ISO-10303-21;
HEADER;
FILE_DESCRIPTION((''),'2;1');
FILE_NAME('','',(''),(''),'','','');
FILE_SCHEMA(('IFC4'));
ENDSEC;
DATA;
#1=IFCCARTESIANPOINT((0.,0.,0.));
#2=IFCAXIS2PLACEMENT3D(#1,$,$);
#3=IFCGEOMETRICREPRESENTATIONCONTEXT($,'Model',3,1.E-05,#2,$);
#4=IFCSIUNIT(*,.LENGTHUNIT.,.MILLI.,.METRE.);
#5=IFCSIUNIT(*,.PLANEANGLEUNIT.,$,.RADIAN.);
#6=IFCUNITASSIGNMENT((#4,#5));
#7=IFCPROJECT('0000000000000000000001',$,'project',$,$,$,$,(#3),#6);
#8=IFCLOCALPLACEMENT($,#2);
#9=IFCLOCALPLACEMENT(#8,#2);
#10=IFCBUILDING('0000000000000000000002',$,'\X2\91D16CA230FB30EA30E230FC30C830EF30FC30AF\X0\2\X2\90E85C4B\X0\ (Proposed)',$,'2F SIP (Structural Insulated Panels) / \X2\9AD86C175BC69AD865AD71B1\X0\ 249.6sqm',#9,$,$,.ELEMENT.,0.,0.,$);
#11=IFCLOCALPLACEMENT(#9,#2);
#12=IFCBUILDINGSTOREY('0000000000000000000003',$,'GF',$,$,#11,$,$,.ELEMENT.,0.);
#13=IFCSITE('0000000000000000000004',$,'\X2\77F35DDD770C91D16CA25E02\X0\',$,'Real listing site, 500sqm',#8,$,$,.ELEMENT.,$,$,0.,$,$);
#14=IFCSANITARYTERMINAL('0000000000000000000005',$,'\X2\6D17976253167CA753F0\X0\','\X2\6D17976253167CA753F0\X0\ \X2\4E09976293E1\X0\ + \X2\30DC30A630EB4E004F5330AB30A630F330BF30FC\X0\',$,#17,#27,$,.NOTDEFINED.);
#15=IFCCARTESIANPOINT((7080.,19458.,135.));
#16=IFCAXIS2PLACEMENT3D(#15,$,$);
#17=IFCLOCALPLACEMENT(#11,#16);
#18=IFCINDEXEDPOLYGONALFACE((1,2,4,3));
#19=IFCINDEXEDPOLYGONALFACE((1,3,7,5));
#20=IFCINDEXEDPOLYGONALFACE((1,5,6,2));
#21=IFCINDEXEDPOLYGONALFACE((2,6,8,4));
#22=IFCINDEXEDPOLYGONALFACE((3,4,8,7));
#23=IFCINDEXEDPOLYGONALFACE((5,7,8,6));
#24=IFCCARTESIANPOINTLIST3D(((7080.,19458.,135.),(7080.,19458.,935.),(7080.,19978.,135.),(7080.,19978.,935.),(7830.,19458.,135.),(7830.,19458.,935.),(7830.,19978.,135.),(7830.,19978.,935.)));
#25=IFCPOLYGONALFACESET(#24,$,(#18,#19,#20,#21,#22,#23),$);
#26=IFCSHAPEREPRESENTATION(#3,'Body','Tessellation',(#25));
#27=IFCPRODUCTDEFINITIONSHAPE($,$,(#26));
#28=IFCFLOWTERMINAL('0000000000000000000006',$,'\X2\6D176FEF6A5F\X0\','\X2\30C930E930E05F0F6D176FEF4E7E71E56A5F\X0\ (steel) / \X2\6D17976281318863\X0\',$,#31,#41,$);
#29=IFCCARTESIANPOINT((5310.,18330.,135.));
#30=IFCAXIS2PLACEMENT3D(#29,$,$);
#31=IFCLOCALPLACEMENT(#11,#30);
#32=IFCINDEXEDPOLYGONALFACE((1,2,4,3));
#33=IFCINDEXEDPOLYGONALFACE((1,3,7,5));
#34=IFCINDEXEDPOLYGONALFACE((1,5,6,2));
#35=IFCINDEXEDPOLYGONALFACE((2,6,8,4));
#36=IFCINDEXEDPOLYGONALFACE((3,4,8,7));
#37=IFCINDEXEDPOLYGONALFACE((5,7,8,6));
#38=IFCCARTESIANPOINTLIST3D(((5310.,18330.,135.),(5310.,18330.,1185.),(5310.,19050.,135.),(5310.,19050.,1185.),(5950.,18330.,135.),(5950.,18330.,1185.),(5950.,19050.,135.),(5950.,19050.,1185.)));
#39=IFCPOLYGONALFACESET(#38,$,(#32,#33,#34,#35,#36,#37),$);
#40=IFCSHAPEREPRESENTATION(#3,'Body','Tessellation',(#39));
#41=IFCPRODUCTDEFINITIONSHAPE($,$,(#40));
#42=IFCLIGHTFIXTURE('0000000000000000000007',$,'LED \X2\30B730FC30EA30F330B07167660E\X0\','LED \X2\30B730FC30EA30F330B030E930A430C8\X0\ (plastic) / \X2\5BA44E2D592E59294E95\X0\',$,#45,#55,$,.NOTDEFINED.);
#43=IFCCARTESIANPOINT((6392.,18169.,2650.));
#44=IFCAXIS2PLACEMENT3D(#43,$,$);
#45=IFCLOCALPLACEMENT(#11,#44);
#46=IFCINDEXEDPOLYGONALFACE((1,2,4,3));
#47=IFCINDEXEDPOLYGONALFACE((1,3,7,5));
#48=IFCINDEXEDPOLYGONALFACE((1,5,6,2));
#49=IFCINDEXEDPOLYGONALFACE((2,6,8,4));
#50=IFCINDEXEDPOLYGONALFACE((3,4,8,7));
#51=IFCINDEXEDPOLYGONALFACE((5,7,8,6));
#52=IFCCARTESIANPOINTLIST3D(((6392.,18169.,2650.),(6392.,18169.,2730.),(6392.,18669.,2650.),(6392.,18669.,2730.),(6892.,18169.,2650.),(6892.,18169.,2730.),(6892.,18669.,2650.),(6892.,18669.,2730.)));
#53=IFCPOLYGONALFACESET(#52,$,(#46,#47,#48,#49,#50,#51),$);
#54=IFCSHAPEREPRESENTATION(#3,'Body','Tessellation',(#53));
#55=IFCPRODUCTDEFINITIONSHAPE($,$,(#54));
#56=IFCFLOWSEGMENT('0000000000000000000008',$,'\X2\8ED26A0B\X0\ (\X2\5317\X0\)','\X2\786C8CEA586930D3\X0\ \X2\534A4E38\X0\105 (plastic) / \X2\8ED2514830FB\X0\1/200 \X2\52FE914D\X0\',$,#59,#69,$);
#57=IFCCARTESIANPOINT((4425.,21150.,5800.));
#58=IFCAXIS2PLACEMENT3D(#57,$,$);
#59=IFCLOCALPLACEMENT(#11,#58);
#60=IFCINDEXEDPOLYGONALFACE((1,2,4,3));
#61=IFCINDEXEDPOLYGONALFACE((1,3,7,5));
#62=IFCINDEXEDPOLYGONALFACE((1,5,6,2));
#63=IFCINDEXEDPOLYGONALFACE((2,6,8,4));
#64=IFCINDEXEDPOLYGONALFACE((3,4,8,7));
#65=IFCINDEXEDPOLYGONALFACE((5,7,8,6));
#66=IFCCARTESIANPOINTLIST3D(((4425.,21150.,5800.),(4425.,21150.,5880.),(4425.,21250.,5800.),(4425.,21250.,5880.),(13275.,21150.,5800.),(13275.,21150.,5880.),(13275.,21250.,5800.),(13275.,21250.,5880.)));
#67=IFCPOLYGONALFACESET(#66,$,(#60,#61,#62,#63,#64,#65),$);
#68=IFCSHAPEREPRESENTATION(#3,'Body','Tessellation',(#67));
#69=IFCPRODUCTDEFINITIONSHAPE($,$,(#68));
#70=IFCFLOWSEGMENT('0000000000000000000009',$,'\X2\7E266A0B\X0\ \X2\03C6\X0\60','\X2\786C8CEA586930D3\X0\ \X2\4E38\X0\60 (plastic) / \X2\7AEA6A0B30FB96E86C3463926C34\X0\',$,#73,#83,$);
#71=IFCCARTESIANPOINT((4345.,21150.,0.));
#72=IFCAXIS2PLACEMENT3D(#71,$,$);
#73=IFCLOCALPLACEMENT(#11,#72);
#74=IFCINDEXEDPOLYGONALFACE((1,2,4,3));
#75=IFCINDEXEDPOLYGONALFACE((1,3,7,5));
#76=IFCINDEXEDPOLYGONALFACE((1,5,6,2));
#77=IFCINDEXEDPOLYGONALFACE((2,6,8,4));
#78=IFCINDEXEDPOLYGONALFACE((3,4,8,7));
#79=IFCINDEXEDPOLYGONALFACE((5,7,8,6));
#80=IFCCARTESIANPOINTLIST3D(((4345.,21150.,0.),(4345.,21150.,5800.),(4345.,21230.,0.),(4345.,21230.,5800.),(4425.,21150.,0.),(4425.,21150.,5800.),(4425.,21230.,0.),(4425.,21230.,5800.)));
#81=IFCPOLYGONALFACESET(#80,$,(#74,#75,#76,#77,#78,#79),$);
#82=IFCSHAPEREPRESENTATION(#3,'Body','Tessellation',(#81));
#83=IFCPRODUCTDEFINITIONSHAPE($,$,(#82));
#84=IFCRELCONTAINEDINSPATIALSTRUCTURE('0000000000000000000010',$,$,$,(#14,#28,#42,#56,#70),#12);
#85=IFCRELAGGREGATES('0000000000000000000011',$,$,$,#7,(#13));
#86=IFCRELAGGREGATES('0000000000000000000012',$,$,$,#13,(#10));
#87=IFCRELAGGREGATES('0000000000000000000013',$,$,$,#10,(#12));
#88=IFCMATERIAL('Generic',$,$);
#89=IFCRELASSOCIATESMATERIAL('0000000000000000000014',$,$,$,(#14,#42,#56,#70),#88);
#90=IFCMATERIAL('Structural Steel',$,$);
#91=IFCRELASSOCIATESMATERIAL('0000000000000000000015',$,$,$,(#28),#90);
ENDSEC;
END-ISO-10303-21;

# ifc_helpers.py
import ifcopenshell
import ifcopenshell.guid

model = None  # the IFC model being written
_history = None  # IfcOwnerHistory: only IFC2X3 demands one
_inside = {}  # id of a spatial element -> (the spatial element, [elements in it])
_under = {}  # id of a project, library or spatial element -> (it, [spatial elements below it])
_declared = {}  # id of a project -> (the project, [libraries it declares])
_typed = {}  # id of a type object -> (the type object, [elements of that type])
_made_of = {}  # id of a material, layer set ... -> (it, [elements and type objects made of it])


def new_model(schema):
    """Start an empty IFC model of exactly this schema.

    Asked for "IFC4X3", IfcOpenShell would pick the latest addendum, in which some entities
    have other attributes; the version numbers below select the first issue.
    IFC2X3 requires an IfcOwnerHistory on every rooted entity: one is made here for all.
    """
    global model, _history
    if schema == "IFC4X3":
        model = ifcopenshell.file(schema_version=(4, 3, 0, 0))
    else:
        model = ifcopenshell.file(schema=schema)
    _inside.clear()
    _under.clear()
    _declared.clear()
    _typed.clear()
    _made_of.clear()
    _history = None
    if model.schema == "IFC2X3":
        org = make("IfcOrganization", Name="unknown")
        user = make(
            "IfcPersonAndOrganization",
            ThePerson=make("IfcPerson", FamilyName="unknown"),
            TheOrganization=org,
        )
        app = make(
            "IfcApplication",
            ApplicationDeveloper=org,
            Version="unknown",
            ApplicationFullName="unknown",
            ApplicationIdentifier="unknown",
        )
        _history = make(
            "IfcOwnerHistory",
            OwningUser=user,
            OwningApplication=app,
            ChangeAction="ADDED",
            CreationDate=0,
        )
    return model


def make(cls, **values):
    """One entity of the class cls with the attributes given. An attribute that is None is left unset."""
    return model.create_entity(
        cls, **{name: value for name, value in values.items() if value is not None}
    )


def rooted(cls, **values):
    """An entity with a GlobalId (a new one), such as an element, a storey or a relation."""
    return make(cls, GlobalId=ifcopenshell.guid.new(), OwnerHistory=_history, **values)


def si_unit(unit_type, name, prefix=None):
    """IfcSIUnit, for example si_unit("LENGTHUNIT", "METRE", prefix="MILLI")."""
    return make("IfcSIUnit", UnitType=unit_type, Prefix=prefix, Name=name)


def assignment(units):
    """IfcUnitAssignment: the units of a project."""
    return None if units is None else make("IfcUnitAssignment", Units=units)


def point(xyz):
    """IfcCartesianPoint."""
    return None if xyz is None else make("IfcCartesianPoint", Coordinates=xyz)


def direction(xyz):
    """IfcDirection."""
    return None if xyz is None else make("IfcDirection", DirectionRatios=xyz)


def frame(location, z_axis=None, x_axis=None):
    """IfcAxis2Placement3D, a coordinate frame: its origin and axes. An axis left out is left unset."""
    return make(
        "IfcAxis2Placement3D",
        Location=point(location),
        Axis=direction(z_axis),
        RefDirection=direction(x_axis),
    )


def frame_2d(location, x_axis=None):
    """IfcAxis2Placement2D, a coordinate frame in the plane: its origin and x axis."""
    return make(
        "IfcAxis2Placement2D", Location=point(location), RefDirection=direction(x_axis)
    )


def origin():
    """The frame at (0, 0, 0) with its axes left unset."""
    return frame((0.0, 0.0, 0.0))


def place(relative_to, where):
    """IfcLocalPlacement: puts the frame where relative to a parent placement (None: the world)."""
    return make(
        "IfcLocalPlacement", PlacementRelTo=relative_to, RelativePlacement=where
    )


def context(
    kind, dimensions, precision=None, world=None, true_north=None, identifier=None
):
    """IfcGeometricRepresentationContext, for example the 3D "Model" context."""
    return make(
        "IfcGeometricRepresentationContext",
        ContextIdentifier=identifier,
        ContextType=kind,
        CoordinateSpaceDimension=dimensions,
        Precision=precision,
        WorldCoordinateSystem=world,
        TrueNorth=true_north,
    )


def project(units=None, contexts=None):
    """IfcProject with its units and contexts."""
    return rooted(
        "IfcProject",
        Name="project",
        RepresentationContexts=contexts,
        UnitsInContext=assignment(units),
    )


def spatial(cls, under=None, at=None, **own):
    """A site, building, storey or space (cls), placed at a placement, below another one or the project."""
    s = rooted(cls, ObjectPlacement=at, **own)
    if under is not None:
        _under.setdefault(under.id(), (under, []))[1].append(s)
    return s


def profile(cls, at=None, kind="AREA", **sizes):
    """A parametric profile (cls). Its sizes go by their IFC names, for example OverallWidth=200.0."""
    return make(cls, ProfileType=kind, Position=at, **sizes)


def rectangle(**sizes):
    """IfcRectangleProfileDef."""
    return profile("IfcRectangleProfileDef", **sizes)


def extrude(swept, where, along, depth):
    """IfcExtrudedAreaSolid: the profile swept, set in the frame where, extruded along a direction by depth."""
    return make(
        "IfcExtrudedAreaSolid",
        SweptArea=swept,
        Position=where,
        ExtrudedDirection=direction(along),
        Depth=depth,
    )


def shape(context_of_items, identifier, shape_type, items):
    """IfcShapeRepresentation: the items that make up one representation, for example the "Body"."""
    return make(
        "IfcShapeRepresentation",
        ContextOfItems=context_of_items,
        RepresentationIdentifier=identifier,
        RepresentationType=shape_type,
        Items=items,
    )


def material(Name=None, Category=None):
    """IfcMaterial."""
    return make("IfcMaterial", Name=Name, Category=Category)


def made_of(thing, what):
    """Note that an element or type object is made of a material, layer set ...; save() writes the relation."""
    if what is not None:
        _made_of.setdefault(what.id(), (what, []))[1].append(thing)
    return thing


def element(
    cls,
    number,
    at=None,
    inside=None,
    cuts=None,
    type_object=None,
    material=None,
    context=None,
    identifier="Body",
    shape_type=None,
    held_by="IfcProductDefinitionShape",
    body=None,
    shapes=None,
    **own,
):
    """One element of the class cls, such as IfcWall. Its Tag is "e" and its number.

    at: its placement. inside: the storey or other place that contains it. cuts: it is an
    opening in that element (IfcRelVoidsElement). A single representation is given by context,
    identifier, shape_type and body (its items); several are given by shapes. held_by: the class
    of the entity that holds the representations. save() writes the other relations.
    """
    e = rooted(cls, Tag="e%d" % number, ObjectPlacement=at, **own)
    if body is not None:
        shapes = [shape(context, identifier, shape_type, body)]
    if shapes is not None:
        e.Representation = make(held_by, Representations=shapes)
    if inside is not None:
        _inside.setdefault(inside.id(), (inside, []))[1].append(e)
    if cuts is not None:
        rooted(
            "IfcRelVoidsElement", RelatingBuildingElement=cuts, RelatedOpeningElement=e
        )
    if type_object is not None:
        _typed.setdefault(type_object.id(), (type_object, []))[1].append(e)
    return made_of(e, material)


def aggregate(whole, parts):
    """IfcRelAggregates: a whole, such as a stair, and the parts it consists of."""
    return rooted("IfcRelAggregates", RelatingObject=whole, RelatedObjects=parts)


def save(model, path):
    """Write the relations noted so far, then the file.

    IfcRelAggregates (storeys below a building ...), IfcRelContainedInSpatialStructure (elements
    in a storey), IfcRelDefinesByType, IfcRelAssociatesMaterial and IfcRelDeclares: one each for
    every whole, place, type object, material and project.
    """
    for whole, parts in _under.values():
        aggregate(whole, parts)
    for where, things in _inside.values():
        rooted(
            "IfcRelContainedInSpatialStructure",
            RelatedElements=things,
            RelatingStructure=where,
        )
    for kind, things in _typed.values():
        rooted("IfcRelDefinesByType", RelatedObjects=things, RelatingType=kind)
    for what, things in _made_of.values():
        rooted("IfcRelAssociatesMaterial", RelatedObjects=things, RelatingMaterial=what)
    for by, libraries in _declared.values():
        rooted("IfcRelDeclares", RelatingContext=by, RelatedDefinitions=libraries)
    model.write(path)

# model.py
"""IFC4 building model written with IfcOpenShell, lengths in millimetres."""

from ifc_helpers import new_model, si_unit, frame, frame_2d, origin, place, context, project, spatial, rectangle, extrude, material, element, save


model = new_model("IFC4")

# Units and contexts
model_context = context("Model", 3, precision=1e-05, world=origin())
ifc_project = project(units=[si_unit("LENGTHUNIT", "METRE", prefix="MILLI"), si_unit("PLANEANGLEUNIT", "RADIAN")], contexts=[model_context])

# Site, building, storey
site_placement = place(None, origin())
site = spatial("IfcSite", under=ifc_project, at=site_placement, Name="石川県金沢市", ObjectType="Real listing site, 500sqm", CompositionType="ELEMENT", RefElevation=0.0)
building_placement = place(site_placement, origin())
building = spatial("IfcBuilding", under=site, at=building_placement, Name="金沢・リモートワーク2部屋 (Proposed)", ObjectType="2F SIP (Structural Insulated Panels) / 高気密高断熱 249.6sqm", CompositionType="ELEMENT", ElevationOfRefHeight=0.0, ElevationOfTerrain=0.0)
storey_placement = place(building_placement, origin())
storey = spatial("IfcBuildingStorey", under=building, at=storey_placement, Name="GF", CompositionType="ELEMENT", Elevation=0.0)

# Sanitary terminal
ifc_material_1 = material(Name="Generic")
sanitary_terminal_placement = place(storey_placement, frame((7080.0, 19458.0, 135.0)))
element("IfcSanitaryTerminal", 1, at=sanitary_terminal_placement, inside=storey, material=ifc_material_1, Name="洗面化粧台", Description="洗面化粧台 三面鏡 + ボウル一体カウンター", PredefinedType="NOTDEFINED", context=model_context, shape_type="SweptSolid", body=[
    extrude(rectangle(XDim=750.0, YDim=520.0, at=frame_2d((375.0, 260.0))), frame((7080.0, 19458.0, 135.0)), (0.0, 0.0, 1.0), 800.0),
])

# Flow terminal
ifc_material_2 = material(Name="Structural Steel")
flow_terminal_placement = place(storey_placement, frame((5310.0, 18330.0, 135.0)))
element("IfcFlowTerminal", 2, at=flow_terminal_placement, inside=storey, material=ifc_material_2, Name="洗濯機", Description="ドラム式洗濯乾燥機 (steel) / 洗面脱衣", context=model_context, shape_type="SweptSolid", body=[
    extrude(rectangle(XDim=640.0, YDim=720.0, at=frame_2d((320.0, 360.0))), frame((5310.0, 18330.0, 135.0)), (0.0, 0.0, 1.0), 1050.0),
])

# Light fixture
light_fixture_placement = place(storey_placement, frame((6392.0, 18169.0, 2650.0)))
element("IfcLightFixture", 3, at=light_fixture_placement, inside=storey, material=ifc_material_1, Name="LED シーリング照明", Description="LED シーリングライト (plastic) / 室中央天井", PredefinedType="NOTDEFINED", context=model_context, shape_type="SweptSolid", body=[
    extrude(rectangle(XDim=500.0, YDim=500.0, at=frame_2d((250.0, 250.0))), frame((6392.0, 18169.0, 2650.0)), (0.0, 0.0, 1.0), 80.0),
])

# Flow segments
flow_segment_1_placement = place(storey_placement, frame((4425.0, 21150.0, 5800.0)))
element("IfcFlowSegment", 4, at=flow_segment_1_placement, inside=storey, material=ifc_material_1, Name="軒樋 (北)", Description="硬質塩ビ 半丸105 (plastic) / 軒先・1/200 勾配", context=model_context, shape_type="SweptSolid", body=[
    extrude(rectangle(XDim=8850.0, YDim=100.0, at=frame_2d((4425.0, 50.0))), frame((4425.0, 21150.0, 5800.0)), (0.0, 0.0, 1.0), 80.0),
])
flow_segment_2_placement = place(storey_placement, frame((4345.0, 21150.0, 0.0)))
element("IfcFlowSegment", 5, at=flow_segment_2_placement, inside=storey, material=ifc_material_1, Name="縦樋 φ60", Description="硬質塩ビ 丸60 (plastic) / 竪樋・雨水排水", context=model_context, shape_type="SweptSolid", body=[
    extrude(rectangle(XDim=80.0, YDim=80.0, at=frame_2d((40.0, 40.0))), frame((4345.0, 21150.0, 0.0)), (0.0, 0.0, 1.0), 5800.0),
])

save(model, "model.ifc")
